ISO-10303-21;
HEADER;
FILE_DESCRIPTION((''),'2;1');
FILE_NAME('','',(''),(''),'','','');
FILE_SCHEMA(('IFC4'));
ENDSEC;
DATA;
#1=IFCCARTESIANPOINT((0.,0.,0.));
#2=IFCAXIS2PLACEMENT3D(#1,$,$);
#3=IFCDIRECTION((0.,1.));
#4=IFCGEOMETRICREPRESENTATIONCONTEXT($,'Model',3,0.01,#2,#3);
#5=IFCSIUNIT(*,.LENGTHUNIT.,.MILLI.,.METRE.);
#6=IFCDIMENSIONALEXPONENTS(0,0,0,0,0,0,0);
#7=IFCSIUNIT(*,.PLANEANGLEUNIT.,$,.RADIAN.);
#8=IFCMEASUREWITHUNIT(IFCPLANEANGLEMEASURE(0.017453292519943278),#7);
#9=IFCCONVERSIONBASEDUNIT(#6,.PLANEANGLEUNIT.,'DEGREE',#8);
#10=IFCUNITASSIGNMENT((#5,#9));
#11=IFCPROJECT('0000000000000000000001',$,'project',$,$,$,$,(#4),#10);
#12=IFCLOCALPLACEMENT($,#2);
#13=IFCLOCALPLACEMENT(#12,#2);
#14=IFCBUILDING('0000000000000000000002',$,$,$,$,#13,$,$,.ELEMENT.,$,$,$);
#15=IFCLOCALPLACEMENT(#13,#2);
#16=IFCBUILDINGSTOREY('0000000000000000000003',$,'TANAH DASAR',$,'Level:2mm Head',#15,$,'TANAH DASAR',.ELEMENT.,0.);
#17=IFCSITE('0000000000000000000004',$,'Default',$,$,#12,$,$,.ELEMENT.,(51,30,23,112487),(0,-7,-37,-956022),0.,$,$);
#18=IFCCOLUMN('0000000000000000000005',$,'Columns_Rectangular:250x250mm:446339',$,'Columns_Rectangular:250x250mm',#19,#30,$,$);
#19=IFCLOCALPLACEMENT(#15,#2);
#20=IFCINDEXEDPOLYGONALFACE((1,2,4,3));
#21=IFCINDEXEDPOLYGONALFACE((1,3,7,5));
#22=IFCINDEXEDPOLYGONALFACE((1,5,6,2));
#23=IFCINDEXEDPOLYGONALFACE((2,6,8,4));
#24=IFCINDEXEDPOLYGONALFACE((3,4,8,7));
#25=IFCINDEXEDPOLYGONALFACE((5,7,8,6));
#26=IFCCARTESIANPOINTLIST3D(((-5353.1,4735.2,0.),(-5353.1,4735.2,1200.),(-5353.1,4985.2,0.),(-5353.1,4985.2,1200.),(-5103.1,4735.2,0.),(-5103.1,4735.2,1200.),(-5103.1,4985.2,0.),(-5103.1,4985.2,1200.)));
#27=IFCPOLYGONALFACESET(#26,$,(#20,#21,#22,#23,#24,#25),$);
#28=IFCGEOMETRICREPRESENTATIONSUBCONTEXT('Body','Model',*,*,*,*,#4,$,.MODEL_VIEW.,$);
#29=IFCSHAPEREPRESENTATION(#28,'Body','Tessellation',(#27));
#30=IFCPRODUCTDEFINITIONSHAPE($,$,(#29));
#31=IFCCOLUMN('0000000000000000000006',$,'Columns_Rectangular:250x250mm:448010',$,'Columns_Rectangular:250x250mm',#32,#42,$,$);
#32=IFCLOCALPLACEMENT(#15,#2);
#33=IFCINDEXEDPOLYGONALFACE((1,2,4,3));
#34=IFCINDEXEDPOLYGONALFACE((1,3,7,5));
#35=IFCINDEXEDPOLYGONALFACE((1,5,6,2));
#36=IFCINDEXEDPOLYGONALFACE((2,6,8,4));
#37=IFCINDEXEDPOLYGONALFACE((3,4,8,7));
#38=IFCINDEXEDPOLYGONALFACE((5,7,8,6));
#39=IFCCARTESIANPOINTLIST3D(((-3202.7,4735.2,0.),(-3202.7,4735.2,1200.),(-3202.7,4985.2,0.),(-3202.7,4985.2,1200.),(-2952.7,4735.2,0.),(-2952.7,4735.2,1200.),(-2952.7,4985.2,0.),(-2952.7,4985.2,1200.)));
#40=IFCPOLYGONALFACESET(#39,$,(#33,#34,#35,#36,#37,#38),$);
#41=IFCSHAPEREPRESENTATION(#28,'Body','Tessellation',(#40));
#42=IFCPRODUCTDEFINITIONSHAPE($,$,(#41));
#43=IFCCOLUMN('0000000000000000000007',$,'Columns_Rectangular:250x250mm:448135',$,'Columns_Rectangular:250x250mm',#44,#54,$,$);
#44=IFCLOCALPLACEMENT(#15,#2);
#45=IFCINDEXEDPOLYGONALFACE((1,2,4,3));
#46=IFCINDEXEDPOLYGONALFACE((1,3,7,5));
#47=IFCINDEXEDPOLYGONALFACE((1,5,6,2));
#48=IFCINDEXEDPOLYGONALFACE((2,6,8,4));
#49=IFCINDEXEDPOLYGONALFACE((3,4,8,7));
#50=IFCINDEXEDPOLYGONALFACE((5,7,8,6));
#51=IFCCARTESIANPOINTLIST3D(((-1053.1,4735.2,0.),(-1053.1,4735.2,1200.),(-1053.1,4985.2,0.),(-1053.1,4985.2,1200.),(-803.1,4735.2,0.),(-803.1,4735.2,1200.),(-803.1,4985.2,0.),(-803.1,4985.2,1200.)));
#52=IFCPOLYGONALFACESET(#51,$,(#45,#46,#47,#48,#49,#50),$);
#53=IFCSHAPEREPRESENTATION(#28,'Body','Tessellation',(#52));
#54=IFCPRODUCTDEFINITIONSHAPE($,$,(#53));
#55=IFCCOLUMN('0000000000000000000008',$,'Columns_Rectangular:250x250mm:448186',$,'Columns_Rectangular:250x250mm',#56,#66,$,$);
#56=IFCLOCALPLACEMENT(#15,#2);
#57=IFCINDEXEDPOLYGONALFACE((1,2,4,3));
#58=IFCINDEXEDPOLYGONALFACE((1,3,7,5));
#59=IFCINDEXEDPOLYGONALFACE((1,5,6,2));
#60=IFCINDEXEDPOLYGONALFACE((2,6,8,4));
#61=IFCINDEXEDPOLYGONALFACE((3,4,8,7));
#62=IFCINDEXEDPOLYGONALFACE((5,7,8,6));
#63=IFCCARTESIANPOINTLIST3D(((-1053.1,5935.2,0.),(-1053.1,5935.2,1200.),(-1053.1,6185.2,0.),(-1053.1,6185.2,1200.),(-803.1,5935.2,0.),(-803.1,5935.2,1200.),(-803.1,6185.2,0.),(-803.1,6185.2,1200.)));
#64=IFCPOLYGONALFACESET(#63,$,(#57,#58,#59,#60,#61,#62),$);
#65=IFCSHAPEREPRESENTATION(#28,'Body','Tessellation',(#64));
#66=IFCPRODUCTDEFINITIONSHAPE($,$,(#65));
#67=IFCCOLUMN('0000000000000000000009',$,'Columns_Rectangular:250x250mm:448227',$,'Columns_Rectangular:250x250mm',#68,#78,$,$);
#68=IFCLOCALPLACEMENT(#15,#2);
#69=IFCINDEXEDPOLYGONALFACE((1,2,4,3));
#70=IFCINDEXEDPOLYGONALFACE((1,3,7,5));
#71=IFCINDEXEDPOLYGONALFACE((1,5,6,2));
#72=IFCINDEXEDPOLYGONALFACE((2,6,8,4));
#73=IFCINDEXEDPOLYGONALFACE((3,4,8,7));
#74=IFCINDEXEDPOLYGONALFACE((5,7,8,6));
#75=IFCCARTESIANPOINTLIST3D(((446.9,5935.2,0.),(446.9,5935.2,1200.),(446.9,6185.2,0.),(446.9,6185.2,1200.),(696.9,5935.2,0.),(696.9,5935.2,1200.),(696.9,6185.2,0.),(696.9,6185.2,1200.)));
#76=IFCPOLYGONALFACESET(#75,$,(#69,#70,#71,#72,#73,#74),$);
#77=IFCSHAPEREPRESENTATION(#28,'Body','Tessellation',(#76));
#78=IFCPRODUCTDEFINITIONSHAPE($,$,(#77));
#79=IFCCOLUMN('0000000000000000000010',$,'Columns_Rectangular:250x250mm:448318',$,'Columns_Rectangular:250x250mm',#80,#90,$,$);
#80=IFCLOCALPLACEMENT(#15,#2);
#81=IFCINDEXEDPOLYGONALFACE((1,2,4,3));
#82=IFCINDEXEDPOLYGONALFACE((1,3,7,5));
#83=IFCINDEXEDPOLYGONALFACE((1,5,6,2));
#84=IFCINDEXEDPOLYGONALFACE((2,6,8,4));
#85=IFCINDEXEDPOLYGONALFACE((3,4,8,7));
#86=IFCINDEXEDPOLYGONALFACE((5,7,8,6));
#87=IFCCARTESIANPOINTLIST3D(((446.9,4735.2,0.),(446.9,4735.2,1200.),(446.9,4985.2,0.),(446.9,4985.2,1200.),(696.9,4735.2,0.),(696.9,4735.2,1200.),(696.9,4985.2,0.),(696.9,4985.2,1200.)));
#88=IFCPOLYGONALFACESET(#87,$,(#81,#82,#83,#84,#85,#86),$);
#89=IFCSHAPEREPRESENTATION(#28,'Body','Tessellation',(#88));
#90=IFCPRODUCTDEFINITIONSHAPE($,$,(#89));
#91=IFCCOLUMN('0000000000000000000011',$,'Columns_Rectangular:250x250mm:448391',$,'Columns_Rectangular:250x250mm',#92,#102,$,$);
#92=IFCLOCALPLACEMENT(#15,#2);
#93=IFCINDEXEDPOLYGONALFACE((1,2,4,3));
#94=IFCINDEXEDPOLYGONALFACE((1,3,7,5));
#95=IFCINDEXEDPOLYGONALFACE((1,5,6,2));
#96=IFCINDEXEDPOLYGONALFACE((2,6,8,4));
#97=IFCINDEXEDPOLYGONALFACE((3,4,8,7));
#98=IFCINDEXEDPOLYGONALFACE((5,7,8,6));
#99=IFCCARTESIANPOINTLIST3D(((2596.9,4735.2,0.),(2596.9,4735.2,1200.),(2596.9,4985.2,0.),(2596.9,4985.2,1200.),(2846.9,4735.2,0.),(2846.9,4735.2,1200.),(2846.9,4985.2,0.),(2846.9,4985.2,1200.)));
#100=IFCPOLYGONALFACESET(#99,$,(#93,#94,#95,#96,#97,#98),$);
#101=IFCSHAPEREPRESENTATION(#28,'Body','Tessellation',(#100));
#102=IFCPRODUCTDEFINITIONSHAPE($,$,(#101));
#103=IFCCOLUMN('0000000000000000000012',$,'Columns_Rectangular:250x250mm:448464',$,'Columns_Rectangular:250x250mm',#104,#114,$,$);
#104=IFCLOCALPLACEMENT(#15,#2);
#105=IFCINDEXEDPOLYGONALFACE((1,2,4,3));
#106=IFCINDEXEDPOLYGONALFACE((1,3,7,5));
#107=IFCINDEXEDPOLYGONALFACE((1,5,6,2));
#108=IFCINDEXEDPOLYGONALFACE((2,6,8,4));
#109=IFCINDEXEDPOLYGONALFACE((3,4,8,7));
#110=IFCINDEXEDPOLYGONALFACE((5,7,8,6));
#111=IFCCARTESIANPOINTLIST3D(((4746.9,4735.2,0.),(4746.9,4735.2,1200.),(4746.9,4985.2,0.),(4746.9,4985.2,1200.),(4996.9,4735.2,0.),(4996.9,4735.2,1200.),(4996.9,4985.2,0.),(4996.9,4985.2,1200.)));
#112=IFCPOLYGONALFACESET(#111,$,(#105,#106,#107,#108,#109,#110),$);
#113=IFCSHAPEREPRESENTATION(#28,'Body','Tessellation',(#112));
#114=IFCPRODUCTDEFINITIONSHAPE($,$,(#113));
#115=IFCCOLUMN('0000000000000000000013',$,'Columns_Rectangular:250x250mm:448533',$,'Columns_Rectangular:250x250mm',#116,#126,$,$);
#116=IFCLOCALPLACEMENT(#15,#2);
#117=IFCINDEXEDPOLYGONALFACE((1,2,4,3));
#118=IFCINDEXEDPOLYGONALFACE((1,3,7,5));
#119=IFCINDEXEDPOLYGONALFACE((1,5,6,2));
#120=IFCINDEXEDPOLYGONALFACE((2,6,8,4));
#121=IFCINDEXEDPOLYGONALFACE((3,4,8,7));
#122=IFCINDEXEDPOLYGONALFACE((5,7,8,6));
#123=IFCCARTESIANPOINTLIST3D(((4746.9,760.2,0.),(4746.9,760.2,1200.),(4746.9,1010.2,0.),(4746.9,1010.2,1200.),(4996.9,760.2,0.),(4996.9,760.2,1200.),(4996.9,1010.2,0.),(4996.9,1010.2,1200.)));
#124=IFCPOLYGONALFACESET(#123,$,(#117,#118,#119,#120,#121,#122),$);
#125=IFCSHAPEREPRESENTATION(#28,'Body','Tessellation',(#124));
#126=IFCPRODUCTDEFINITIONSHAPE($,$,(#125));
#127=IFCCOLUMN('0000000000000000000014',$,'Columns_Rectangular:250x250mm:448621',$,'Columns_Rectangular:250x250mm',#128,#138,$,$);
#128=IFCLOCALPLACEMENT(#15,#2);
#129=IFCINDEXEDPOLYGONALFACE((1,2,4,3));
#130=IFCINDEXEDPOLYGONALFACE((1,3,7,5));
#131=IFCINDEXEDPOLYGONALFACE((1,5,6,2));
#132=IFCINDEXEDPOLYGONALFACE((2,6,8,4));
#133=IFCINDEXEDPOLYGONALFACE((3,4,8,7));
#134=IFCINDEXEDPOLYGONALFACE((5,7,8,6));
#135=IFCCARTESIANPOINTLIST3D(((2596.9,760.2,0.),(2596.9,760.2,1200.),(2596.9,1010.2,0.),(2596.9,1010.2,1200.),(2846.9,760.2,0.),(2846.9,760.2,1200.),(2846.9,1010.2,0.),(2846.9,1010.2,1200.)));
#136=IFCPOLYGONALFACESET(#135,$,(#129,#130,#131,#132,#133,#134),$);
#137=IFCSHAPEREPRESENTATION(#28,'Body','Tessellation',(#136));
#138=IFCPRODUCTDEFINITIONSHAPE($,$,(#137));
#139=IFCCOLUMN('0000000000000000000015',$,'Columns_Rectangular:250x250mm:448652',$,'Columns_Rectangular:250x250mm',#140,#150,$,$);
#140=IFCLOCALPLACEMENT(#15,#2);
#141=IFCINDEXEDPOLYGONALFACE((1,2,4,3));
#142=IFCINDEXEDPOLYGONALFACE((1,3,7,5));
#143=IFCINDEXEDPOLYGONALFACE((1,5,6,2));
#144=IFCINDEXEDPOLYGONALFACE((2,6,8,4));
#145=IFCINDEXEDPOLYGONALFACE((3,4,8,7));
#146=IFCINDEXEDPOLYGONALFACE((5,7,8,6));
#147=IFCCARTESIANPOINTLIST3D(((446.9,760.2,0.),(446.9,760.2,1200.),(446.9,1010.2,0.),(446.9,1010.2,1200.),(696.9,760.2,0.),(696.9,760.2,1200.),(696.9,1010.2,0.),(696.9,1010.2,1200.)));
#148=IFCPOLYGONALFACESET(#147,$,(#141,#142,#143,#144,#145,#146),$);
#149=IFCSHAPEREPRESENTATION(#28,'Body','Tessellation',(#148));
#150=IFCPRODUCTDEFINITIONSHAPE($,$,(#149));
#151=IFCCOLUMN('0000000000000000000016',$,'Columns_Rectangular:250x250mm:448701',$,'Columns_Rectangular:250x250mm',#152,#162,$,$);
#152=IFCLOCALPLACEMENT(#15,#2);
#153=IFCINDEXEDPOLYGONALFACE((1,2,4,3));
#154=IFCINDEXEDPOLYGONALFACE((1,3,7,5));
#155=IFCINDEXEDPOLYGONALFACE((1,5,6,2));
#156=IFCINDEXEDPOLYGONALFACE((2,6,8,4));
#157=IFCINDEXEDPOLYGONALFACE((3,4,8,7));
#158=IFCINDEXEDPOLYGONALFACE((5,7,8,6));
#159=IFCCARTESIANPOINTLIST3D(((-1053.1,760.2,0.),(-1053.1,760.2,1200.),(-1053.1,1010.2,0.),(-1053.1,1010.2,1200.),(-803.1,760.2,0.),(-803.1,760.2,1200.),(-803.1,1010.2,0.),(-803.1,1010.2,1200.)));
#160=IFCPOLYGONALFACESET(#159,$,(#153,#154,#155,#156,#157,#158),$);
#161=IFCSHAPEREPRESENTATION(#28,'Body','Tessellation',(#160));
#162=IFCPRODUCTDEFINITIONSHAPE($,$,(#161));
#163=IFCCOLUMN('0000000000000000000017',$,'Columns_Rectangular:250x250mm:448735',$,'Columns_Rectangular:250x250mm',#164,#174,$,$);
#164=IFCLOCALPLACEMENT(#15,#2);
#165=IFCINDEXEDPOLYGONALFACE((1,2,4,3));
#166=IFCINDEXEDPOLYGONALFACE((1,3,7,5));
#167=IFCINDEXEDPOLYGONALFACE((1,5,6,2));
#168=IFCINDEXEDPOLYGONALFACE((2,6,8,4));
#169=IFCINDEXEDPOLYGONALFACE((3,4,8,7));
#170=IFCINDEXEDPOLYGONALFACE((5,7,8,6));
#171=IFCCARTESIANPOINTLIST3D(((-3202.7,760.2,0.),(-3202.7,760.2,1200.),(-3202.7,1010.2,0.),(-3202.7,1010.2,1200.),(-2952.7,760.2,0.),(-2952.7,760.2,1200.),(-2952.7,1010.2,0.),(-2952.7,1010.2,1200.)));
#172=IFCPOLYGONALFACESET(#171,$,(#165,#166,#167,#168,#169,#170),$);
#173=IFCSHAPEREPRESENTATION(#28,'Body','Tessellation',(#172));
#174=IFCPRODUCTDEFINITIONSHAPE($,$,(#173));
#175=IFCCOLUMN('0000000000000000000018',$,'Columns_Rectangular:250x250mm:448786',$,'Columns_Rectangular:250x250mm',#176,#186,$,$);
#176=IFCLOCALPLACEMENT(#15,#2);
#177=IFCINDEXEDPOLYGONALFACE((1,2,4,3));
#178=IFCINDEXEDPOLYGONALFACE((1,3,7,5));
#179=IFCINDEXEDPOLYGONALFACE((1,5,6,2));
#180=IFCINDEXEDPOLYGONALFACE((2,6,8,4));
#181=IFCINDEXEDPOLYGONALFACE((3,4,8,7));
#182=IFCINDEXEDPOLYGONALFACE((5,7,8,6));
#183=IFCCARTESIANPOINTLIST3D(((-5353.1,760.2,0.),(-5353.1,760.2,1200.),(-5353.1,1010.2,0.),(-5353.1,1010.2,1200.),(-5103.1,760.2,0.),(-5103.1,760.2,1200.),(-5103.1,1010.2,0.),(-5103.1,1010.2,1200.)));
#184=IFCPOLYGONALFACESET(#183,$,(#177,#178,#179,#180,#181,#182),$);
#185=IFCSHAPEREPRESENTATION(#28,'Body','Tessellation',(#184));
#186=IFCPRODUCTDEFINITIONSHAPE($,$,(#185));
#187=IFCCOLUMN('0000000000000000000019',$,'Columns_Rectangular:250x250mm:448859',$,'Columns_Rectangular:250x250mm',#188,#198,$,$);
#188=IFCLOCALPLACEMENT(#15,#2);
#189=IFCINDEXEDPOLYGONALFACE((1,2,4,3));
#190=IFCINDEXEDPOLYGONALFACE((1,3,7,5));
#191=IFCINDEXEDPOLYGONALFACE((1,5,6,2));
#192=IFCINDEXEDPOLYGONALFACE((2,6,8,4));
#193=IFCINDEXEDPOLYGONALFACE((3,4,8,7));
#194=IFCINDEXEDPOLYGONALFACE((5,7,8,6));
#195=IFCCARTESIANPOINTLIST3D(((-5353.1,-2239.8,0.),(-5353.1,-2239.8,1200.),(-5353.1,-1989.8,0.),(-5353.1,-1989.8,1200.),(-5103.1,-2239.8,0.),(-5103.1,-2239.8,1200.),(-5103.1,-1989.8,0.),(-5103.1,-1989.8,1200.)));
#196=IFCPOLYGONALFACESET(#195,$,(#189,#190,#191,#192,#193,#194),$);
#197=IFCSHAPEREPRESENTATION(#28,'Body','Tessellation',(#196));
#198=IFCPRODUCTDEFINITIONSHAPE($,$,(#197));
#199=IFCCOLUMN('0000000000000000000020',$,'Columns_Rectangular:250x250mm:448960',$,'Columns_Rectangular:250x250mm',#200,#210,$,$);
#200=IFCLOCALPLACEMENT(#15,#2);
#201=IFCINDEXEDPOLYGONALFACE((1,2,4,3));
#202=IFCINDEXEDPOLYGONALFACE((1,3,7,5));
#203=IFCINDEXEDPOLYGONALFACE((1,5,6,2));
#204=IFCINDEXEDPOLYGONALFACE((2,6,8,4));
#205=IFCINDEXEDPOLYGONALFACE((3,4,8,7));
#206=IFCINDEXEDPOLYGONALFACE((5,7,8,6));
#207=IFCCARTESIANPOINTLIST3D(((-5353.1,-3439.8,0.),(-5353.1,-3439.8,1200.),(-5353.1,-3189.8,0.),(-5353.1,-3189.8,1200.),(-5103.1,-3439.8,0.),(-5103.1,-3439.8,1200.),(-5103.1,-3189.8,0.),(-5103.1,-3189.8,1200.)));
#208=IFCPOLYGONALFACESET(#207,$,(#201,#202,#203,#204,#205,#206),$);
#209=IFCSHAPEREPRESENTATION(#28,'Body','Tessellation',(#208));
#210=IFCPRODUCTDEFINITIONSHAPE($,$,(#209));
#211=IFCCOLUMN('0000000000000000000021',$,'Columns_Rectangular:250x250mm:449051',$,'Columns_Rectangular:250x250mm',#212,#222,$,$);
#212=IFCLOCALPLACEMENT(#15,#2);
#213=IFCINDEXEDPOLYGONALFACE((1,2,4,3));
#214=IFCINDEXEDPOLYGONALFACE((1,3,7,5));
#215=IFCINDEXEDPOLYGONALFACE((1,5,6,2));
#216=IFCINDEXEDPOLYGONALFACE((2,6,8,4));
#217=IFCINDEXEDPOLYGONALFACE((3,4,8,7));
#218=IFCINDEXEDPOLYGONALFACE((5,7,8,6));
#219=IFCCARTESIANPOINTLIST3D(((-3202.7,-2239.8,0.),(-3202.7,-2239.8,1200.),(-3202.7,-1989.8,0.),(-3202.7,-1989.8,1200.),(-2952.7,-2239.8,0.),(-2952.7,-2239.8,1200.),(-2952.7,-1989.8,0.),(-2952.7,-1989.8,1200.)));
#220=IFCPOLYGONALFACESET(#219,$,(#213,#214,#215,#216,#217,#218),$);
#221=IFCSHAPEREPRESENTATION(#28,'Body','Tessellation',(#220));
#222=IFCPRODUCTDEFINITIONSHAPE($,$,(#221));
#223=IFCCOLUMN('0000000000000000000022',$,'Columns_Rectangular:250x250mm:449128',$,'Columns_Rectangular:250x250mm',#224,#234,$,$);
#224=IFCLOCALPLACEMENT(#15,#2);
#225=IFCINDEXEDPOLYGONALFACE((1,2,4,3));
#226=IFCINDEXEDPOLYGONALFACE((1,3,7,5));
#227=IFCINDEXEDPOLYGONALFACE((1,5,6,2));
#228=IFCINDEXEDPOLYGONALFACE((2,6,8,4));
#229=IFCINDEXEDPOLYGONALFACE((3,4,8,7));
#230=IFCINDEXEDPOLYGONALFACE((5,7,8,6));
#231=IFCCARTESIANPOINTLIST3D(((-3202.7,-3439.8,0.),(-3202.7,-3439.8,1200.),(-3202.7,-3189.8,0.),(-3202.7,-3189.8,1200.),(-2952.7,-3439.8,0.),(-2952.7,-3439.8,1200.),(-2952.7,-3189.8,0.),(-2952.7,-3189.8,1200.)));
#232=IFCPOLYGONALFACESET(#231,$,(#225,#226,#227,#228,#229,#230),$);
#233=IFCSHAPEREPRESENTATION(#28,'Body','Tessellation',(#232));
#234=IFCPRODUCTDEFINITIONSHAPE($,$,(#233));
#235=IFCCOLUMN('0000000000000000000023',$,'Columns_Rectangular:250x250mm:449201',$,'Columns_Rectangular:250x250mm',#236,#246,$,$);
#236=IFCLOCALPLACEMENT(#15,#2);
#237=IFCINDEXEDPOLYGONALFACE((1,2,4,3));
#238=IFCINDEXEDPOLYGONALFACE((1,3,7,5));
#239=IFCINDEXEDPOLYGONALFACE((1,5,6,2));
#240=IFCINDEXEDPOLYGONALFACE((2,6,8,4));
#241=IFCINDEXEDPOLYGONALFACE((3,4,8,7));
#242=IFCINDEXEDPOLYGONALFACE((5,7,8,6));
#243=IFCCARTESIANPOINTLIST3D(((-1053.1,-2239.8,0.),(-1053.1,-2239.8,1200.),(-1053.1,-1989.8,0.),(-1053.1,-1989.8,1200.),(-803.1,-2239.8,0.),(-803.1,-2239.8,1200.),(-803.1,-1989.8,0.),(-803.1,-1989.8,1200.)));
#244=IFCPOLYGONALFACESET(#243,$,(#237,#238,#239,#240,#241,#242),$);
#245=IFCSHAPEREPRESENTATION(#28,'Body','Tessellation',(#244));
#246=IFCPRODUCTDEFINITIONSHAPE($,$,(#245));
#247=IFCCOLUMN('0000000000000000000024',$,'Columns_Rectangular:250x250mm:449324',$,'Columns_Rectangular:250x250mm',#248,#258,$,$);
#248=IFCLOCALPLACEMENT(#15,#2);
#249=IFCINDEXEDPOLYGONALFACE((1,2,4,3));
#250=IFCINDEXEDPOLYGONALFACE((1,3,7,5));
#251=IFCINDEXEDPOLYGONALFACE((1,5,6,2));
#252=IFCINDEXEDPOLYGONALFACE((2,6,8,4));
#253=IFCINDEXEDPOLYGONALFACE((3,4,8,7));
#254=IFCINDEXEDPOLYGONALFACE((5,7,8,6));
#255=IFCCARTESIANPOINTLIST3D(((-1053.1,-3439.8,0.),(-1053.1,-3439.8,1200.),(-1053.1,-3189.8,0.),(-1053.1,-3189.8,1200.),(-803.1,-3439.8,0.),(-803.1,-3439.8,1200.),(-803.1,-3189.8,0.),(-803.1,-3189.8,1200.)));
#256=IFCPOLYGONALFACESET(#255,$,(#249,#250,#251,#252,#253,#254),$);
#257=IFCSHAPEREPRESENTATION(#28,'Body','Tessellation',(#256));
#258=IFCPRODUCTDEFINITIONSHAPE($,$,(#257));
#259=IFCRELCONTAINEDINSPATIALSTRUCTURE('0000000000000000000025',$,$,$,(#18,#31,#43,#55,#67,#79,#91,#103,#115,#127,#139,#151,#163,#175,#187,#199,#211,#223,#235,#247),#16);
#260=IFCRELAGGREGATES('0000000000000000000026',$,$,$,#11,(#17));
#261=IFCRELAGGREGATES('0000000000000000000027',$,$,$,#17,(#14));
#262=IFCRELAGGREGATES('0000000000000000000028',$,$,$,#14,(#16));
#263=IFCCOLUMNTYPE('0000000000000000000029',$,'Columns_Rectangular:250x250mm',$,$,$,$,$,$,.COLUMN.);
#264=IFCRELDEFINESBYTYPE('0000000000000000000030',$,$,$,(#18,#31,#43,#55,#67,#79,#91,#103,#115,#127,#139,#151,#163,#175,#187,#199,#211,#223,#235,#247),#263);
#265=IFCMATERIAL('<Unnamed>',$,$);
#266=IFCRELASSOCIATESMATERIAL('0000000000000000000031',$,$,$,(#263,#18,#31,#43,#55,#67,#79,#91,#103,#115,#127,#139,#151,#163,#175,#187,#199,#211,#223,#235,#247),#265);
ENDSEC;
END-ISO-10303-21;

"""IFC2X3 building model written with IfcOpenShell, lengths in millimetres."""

from ifc_helpers import new_model, entity, si_unit, converted_unit, direction, frame, origin, origin_2d_with_axis, place, context, subcontext, project, spatial, rectangle, extrude, source, transform, mapped, material, type_object, type_shapes, element, save


model = new_model("IFC2X3")

# Units and contexts
model_context = context("Model", 3, precision=0.01, world=origin(), true_north=direction((0.0, 1.0)))
body_context = subcontext(model_context, "Body", "Model", "MODEL_VIEW")
ifc_project = project(units=[si_unit("LENGTHUNIT", "METRE", prefix="MILLI"), converted_unit("PLANEANGLEUNIT", "DEGREE", entity("IfcPlaneAngleMeasure", 0.017453292519943278), si_unit("PLANEANGLEUNIT", "RADIAN"), dimensions=[0, 0, 0, 0, 0, 0, 0])], contexts=[model_context])

# Site, building, storey
site_placement = place(None, origin())
site = spatial("IfcSite", under=ifc_project, at=site_placement, Name="Default", CompositionType="ELEMENT", RefLatitude=(51, 30, 23, 112487), RefLongitude=(0, -7, -37, -956022), RefElevation=0.0)
building_placement = place(site_placement, origin())
building = spatial("IfcBuilding", under=site, at=building_placement, CompositionType="ELEMENT")
storey_placement = place(building_placement, origin())
storey = spatial("IfcBuildingStorey", under=building, at=storey_placement, Name="TANAH DASAR", ObjectType="Level:2mm Head", LongName="TANAH DASAR", CompositionType="ELEMENT", Elevation=0.0)

# Columns
ifc_material_1 = material(Name="<Unnamed>")
column_type = type_object("IfcColumnType", Name="Columns_Rectangular:250x250mm", PredefinedType="COLUMN", material=ifc_material_1)
shared_shape = source(origin(), body_context, "Body", "SweptSolid", [
    extrude(rectangle(XDim=250.0, YDim=250.0, at=origin_2d_with_axis()), frame((0.0, 0.0, 0.0), z_axis=(0.0, 0.0, 1.0), x_axis=(-1.0, 0.0, 0.0)), (0.0, 0.0, 1.0), 1200.0),
])
type_shapes(column_type, [shared_shape])
for number, where, name in (
    (1, (-5228.1, 4860.2, 0.0), "Columns_Rectangular:250x250mm:446339"),
    (2, (-3077.7, 4860.2, 0.0), "Columns_Rectangular:250x250mm:448010"),
    (3, (-928.1, 4860.2, 0.0), "Columns_Rectangular:250x250mm:448135"),
    (4, (-928.1, 6060.2, 0.0), "Columns_Rectangular:250x250mm:448186"),
    (5, (571.9, 6060.2, 0.0), "Columns_Rectangular:250x250mm:448227"),
    (6, (571.9, 4860.2, 0.0), "Columns_Rectangular:250x250mm:448318"),
    (7, (2721.9, 4860.2, 0.0), "Columns_Rectangular:250x250mm:448391"),
    (8, (4871.9, 4860.2, 0.0), "Columns_Rectangular:250x250mm:448464"),
    (9, (4871.9, 885.2, 0.0), "Columns_Rectangular:250x250mm:448533"),
    (10, (2721.9, 885.2, 0.0), "Columns_Rectangular:250x250mm:448621"),
    (11, (571.9, 885.2, 0.0), "Columns_Rectangular:250x250mm:448652"),
    (12, (-928.1, 885.2, 0.0), "Columns_Rectangular:250x250mm:448701"),
    (13, (-3077.7, 885.2, 0.0), "Columns_Rectangular:250x250mm:448735"),
    (14, (-5228.1, 885.2, 0.0), "Columns_Rectangular:250x250mm:448786"),
    (15, (-5228.1, -2114.8, 0.0), "Columns_Rectangular:250x250mm:448859"),
    (16, (-5228.1, -3314.8, 0.0), "Columns_Rectangular:250x250mm:448960"),
    (17, (-3077.7, -2114.8, 0.0), "Columns_Rectangular:250x250mm:449051"),
    (18, (-3077.7, -3314.8, 0.0), "Columns_Rectangular:250x250mm:449128"),
    (19, (-928.1, -2114.8, 0.0), "Columns_Rectangular:250x250mm:449201"),
    (20, (-928.1, -3314.8, 0.0), "Columns_Rectangular:250x250mm:449324"),
):
    element("IfcColumn", number, at=place(storey_placement, frame(where)), inside=storey, type_object=column_type, material=ifc_material_1, Name=name, ObjectType="Columns_Rectangular:250x250mm", context=body_context, shape_type="MappedRepresentation", body=[
        mapped(shared_shape, transform((0.0, 0.0, 0.0), scale=1.0)),
    ])

save(model, "model.ifc")
